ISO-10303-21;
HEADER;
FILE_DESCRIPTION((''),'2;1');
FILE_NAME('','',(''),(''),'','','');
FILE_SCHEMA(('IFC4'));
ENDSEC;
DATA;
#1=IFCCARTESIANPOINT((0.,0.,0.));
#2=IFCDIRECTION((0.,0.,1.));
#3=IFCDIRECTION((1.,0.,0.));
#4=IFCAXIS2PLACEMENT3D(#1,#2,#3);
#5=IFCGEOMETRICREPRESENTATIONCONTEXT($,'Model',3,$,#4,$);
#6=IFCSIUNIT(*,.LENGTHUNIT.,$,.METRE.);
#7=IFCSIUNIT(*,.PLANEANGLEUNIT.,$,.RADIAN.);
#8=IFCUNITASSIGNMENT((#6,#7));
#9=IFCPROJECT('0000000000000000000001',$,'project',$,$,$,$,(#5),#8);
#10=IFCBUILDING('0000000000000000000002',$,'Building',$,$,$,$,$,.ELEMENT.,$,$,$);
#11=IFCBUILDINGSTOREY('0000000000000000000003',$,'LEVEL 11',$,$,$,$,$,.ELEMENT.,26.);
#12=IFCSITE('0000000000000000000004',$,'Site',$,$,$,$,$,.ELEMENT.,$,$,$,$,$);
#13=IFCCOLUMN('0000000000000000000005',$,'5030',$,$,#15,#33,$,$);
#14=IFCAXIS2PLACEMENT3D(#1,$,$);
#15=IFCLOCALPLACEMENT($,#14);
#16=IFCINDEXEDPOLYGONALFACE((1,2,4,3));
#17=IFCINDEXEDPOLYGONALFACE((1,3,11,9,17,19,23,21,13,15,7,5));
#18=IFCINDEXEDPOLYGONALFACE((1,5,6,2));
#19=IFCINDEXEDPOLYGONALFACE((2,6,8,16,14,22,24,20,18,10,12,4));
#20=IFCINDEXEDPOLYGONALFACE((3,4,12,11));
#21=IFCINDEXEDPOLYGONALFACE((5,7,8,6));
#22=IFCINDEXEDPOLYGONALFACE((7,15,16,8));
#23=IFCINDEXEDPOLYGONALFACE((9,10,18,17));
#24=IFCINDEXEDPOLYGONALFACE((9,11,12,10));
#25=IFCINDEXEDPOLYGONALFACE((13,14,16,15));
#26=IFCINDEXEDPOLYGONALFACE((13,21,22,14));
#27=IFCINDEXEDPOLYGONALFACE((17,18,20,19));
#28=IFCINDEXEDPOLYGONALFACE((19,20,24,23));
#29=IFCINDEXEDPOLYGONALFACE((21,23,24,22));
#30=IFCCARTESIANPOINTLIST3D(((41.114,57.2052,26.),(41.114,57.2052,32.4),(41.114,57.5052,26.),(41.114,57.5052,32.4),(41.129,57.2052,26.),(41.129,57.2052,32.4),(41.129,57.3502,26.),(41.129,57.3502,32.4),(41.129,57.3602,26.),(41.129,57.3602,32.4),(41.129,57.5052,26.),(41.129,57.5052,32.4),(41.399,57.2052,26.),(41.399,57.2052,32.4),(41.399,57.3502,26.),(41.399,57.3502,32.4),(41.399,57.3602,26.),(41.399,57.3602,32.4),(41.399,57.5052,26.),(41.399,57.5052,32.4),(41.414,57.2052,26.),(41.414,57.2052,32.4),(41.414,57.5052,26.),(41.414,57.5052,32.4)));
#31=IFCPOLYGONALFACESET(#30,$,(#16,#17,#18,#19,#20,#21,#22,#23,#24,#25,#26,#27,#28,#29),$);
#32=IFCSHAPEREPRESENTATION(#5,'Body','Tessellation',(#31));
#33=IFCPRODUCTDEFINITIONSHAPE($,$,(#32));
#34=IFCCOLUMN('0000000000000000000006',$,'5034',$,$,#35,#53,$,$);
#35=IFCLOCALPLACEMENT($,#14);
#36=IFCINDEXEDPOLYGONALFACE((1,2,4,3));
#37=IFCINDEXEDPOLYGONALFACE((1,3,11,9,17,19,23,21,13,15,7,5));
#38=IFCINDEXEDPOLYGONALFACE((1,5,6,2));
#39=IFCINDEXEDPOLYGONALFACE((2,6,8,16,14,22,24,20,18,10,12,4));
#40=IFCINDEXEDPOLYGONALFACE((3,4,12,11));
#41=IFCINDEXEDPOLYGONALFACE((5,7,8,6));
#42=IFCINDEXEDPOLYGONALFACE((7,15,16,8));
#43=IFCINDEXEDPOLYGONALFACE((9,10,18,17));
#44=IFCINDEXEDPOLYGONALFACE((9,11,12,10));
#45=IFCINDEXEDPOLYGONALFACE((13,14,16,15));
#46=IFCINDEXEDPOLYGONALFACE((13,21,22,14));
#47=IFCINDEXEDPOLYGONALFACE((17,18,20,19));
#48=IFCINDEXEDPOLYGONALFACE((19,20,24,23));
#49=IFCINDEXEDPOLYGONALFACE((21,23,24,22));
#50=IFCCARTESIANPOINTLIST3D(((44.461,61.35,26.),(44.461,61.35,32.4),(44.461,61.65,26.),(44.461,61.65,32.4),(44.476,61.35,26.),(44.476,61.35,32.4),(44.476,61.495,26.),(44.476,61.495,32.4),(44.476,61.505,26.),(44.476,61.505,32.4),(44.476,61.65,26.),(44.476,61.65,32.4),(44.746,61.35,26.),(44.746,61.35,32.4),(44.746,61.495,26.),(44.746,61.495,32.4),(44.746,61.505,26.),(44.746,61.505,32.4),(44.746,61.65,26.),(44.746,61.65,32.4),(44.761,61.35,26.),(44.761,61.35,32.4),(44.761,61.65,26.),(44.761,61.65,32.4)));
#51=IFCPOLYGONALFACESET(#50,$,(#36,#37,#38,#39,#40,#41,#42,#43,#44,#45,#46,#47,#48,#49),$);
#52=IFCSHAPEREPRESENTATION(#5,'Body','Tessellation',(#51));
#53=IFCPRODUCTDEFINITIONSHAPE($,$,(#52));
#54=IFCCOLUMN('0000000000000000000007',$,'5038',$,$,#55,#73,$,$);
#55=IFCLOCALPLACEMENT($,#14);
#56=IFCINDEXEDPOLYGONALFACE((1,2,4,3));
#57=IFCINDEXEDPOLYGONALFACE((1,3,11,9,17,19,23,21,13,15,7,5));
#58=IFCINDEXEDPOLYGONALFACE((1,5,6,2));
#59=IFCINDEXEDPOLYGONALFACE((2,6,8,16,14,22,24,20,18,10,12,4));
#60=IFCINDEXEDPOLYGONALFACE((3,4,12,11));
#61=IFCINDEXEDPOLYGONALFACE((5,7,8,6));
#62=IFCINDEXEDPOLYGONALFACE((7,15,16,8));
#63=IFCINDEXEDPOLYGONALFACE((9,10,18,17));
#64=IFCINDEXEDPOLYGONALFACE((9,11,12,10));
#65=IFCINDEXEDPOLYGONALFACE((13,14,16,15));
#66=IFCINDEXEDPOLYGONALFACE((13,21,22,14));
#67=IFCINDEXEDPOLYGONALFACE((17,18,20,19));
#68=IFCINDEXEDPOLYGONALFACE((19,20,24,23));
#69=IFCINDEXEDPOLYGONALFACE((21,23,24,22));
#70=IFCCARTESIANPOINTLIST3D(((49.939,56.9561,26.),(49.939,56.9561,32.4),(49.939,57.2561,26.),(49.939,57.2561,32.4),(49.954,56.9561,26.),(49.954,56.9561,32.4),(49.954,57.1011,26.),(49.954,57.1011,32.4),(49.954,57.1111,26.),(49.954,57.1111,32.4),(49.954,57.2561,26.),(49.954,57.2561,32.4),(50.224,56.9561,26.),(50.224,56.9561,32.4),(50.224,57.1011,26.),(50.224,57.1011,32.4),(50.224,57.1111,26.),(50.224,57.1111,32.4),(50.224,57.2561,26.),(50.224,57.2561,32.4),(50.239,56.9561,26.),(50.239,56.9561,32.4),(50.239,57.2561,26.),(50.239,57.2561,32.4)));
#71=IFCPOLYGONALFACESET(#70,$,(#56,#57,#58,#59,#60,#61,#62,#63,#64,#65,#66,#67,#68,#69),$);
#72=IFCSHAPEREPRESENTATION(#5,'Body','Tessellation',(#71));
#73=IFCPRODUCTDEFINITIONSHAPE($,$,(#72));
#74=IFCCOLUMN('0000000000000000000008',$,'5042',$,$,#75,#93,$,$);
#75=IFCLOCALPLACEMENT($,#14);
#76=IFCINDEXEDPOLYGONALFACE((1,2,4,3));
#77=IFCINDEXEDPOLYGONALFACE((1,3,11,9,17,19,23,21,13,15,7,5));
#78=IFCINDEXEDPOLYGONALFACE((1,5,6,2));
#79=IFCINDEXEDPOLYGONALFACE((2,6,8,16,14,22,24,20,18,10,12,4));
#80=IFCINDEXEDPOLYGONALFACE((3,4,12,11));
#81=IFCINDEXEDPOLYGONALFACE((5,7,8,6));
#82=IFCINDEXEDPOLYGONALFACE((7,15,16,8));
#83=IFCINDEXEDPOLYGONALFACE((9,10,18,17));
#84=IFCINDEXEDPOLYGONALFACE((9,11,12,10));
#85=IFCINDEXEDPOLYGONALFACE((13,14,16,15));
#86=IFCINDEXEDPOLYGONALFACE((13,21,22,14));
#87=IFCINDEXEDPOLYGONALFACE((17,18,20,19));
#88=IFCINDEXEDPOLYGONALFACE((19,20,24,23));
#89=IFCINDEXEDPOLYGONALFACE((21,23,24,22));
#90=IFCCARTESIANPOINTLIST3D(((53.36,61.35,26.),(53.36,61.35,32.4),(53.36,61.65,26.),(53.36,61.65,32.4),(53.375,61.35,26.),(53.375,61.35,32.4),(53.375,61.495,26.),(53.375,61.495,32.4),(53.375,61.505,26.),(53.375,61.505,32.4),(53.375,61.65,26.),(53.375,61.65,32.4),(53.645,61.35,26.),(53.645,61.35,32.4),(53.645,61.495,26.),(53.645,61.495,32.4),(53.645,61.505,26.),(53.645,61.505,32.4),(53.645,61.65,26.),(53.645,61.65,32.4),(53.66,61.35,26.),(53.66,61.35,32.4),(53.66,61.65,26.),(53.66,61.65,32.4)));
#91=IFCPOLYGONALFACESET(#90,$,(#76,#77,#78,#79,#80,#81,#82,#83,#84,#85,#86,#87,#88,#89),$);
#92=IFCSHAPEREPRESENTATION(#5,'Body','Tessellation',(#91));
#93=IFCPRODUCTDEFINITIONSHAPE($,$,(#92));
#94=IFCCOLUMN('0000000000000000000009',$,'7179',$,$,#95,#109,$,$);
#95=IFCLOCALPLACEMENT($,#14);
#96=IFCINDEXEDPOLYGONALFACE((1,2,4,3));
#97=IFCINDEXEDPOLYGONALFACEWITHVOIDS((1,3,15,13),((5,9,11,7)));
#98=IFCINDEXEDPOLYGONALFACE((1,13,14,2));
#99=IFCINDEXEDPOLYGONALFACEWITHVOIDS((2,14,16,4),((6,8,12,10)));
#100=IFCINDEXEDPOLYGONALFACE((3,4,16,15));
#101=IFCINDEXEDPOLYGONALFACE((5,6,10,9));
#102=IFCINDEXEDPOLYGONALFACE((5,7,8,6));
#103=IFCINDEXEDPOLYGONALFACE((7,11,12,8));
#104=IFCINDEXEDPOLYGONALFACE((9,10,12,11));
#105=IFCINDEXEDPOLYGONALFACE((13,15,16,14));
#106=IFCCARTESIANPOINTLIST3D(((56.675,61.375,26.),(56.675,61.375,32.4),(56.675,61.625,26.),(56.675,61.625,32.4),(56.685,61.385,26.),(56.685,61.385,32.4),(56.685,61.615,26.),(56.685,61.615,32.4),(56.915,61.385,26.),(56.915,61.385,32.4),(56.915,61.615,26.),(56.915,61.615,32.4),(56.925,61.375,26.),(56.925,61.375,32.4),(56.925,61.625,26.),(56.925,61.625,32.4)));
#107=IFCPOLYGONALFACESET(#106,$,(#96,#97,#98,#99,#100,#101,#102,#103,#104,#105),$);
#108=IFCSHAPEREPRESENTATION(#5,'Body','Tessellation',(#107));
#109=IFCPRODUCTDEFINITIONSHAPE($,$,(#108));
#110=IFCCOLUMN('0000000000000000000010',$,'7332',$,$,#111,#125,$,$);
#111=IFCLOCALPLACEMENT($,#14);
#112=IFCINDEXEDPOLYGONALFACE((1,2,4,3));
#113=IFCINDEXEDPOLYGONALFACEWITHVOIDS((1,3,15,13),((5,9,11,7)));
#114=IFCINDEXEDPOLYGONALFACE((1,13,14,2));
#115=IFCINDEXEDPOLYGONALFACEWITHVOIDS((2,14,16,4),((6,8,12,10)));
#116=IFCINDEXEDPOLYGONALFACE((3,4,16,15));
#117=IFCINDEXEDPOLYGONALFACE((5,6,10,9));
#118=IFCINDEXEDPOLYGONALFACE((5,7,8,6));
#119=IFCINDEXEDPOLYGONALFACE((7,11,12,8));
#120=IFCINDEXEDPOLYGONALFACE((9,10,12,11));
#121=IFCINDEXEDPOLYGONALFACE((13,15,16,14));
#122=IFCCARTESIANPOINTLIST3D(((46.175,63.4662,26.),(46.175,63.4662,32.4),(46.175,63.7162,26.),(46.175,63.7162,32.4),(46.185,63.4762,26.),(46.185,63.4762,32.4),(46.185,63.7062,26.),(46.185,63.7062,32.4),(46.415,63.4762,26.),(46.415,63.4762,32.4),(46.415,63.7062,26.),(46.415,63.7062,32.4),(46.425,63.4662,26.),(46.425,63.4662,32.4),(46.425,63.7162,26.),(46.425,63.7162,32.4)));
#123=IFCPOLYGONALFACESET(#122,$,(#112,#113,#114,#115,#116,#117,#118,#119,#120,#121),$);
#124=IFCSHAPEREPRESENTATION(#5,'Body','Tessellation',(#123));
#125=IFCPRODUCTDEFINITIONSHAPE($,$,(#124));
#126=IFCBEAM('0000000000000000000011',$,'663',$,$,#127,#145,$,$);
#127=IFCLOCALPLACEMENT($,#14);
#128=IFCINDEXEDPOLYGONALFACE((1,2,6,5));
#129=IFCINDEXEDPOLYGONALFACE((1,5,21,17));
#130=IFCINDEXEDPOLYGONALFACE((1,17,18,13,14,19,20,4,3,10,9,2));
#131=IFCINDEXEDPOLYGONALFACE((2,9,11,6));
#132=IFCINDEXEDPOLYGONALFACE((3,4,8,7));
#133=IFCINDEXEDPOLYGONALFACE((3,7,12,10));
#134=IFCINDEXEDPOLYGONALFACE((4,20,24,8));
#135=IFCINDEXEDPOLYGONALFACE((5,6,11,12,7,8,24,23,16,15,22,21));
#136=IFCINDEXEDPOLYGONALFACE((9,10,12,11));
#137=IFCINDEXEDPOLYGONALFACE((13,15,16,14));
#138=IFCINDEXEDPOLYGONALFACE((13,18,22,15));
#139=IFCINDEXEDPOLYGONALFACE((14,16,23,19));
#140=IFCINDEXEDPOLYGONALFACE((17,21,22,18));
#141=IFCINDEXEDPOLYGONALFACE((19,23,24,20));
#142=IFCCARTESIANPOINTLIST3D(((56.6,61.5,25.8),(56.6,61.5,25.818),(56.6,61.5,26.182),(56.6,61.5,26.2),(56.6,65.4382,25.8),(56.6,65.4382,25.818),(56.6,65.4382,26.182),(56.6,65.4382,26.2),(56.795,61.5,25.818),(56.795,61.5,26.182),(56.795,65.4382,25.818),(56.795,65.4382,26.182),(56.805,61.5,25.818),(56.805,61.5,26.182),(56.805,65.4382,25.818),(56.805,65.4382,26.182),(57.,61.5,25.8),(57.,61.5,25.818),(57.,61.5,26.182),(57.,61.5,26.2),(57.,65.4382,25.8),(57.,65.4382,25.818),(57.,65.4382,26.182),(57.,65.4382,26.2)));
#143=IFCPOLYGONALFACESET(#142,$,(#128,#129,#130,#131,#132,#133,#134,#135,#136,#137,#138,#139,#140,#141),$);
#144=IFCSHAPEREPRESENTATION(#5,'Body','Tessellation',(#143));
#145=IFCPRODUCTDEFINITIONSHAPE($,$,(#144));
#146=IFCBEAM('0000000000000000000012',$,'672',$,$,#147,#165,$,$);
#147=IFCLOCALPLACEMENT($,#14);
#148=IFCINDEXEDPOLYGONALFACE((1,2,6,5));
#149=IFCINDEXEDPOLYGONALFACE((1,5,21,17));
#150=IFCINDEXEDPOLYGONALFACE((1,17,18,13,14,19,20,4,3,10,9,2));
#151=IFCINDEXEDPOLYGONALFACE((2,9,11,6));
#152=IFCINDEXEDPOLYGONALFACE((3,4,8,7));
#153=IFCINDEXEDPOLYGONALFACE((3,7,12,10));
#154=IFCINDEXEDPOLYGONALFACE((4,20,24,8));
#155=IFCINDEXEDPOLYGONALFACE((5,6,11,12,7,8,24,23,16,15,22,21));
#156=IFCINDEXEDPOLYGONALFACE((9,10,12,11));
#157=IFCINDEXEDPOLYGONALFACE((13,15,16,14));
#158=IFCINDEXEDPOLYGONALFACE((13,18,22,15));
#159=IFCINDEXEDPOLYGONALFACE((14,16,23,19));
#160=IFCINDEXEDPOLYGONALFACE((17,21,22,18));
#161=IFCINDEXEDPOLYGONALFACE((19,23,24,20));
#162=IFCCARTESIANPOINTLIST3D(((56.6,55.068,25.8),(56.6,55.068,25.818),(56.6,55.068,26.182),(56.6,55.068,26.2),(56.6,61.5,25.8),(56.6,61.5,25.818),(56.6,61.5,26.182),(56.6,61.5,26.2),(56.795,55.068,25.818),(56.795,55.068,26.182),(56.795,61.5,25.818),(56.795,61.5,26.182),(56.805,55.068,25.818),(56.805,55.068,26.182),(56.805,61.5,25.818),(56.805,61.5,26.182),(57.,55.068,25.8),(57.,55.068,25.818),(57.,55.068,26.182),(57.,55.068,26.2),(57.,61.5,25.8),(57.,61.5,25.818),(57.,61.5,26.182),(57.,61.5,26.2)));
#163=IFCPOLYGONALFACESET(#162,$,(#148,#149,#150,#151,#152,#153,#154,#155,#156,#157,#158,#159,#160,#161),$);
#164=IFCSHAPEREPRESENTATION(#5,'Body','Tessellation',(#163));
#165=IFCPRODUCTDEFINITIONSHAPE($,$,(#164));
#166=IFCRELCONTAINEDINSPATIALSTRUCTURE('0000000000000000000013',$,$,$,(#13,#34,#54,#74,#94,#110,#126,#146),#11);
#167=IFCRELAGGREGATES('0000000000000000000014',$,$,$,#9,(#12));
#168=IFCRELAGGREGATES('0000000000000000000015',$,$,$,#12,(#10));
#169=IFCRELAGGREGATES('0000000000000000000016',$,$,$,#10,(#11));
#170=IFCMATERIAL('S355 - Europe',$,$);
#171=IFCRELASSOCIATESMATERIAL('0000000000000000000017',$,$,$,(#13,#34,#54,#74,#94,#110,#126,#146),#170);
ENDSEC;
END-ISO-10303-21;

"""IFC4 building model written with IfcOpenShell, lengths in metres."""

from ifc_helpers import new_model, si_unit, frame, origin_with_axes, origin_2d_with_axis, place, context, project, spatial, hollow_rectangle, i_section, extrude, material, material_profile, profile_set, profile_usage, element, save


model = new_model("IFC4")

# Units and contexts
model_context = context("Model", 3, world=origin_with_axes())
ifc_project = project(units=[si_unit("LENGTHUNIT", "METRE"), si_unit("PLANEANGLEUNIT", "RADIAN")], contexts=[model_context])

# Site, building, storey
site = spatial("IfcSite", under=ifc_project, Name="Site", CompositionType="ELEMENT")
building = spatial("IfcBuilding", under=site, Name="Building", CompositionType="ELEMENT")
storey = spatial("IfcBuildingStorey", under=building, Name="LEVEL 11", CompositionType="ELEMENT", Elevation=26.0)

# Columns
ifc_material = material(Name="S355 - Europe")
ifc_material_profile_1 = material_profile(ifc_material, i_section(OverallWidth=0.3, OverallDepth=0.3, WebThickness=0.01, FlangeThickness=0.015, at=origin_2d_with_axis()))
ifc_profile_set_1 = profile_set([ifc_material_profile_1])
ifc_profile_usage_1 = profile_usage(ifc_profile_set_1, cardinal=10)
column_1_placement = place(None, frame((41.264, 57.3552, 26.0), z_axis=(0.0, 0.0, 1.0), x_axis=(0.0, -1.0, 0.0)))
element("IfcColumn", 1, at=column_1_placement, inside=storey, material=ifc_profile_usage_1, Name="5030", context=model_context, shape_type="SweptSolid", body=[
    extrude(i_section(OverallWidth=0.3, OverallDepth=0.3, WebThickness=0.01, FlangeThickness=0.015, at=origin_2d_with_axis()), origin_with_axes(), (0.0, 0.0, 1.0), 6.4),
])
ifc_material_profile_2 = material_profile(ifc_material, i_section(OverallWidth=0.3, OverallDepth=0.3, WebThickness=0.01, FlangeThickness=0.015, at=origin_2d_with_axis()))
ifc_profile_set_2 = profile_set([ifc_material_profile_2])
ifc_profile_usage_2 = profile_usage(ifc_profile_set_2, cardinal=10)
column_2_placement = place(None, frame((44.611, 61.5, 26.0), z_axis=(0.0, 0.0, 1.0), x_axis=(0.0, -1.0, 0.0)))
element("IfcColumn", 2, at=column_2_placement, inside=storey, material=ifc_profile_usage_2, Name="5034", context=model_context, shape_type="SweptSolid", body=[
    extrude(i_section(OverallWidth=0.3, OverallDepth=0.3, WebThickness=0.01, FlangeThickness=0.015, at=origin_2d_with_axis()), origin_with_axes(), (0.0, 0.0, 1.0), 6.4),
])
ifc_material_profile_3 = material_profile(ifc_material, i_section(OverallWidth=0.3, OverallDepth=0.3, WebThickness=0.01, FlangeThickness=0.015, at=origin_2d_with_axis()))
ifc_profile_set_3 = profile_set([ifc_material_profile_3])
ifc_profile_usage_3 = profile_usage(ifc_profile_set_3, cardinal=10)
column_3_placement = place(None, frame((50.089, 57.1061, 26.0), z_axis=(0.0, 0.0, 1.0), x_axis=(0.0, -1.0, 0.0)))
element("IfcColumn", 3, at=column_3_placement, inside=storey, material=ifc_profile_usage_3, Name="5038", context=model_context, shape_type="SweptSolid", body=[
    extrude(i_section(OverallWidth=0.3, OverallDepth=0.3, WebThickness=0.01, FlangeThickness=0.015, at=origin_2d_with_axis()), origin_with_axes(), (0.0, 0.0, 1.0), 6.4),
])
ifc_material_profile_4 = material_profile(ifc_material, i_section(OverallWidth=0.3, OverallDepth=0.3, WebThickness=0.01, FlangeThickness=0.015, at=origin_2d_with_axis()))
ifc_profile_set_4 = profile_set([ifc_material_profile_4])
ifc_profile_usage_4 = profile_usage(ifc_profile_set_4, cardinal=10)
column_4_placement = place(None, frame((53.51, 61.5, 26.0), z_axis=(0.0, 0.0, 1.0), x_axis=(0.0, -1.0, 0.0)))
element("IfcColumn", 4, at=column_4_placement, inside=storey, material=ifc_profile_usage_4, Name="5042", context=model_context, shape_type="SweptSolid", body=[
    extrude(i_section(OverallWidth=0.3, OverallDepth=0.3, WebThickness=0.01, FlangeThickness=0.015, at=origin_2d_with_axis()), origin_with_axes(), (0.0, 0.0, 1.0), 6.4),
])
ifc_material_profile_5 = material_profile(ifc_material, hollow_rectangle(XDim=0.25, YDim=0.25, WallThickness=0.01, at=origin_2d_with_axis()))
ifc_profile_set_5 = profile_set([ifc_material_profile_5])
ifc_profile_usage_5 = profile_usage(ifc_profile_set_5, cardinal=10)
column_5_placement = place(None, frame((56.8, 61.5, 26.0), z_axis=(0.0, 0.0, 1.0), x_axis=(0.0, -1.0, 0.0)))
element("IfcColumn", 5, at=column_5_placement, inside=storey, material=ifc_profile_usage_5, Name="7179", context=model_context, shape_type="SweptSolid", body=[
    extrude(hollow_rectangle(XDim=0.25, YDim=0.25, WallThickness=0.01, at=origin_2d_with_axis()), origin_with_axes(), (0.0, 0.0, 1.0), 6.4),
])
ifc_material_profile_6 = material_profile(ifc_material, hollow_rectangle(XDim=0.25, YDim=0.25, WallThickness=0.01, at=origin_2d_with_axis()))
ifc_profile_set_6 = profile_set([ifc_material_profile_6])
ifc_profile_usage_6 = profile_usage(ifc_profile_set_6, cardinal=10)
column_6_placement = place(None, frame((46.3, 63.5912, 26.0), z_axis=(0.0, 0.0, 1.0), x_axis=(0.0, -1.0, 0.0)))
element("IfcColumn", 6, at=column_6_placement, inside=storey, material=ifc_profile_usage_6, Name="7332", context=model_context, shape_type="SweptSolid", body=[
    extrude(hollow_rectangle(XDim=0.25, YDim=0.25, WallThickness=0.01, at=origin_2d_with_axis()), origin_with_axes(), (0.0, 0.0, 1.0), 6.4),
])

# Beams
ifc_material_profile_7 = material_profile(ifc_material, i_section(OverallWidth=0.4, OverallDepth=0.4, WebThickness=0.01, FlangeThickness=0.018, at=origin_2d_with_axis()))
ifc_profile_set_7 = profile_set([ifc_material_profile_7])
ifc_profile_usage_7 = profile_usage(ifc_profile_set_7, cardinal=10)
beam_1_placement = place(None, frame((56.8, 61.5, 26.0), z_axis=(0.0, 1.0, 0.0), x_axis=(-1.0, 0.0, 0.0)))
element("IfcBeam", 7, at=beam_1_placement, inside=storey, material=ifc_profile_usage_7, Name="663", context=model_context, shape_type="SweptSolid", body=[
    extrude(i_section(OverallWidth=0.4, OverallDepth=0.4, WebThickness=0.01, FlangeThickness=0.018, at=origin_2d_with_axis()), origin_with_axes(), (0.0, 0.0, 1.0), 3.9382),
])
ifc_material_profile_8 = material_profile(ifc_material, i_section(OverallWidth=0.4, OverallDepth=0.4, WebThickness=0.01, FlangeThickness=0.018, at=origin_2d_with_axis()))
ifc_profile_set_8 = profile_set([ifc_material_profile_8])
ifc_profile_usage_8 = profile_usage(ifc_profile_set_8, cardinal=10)
beam_2_placement = place(None, frame((56.8, 55.068, 26.0), z_axis=(0.0, 1.0, 0.0), x_axis=(-1.0, 0.0, 0.0)))
element("IfcBeam", 8, at=beam_2_placement, inside=storey, material=ifc_profile_usage_8, Name="672", context=model_context, shape_type="SweptSolid", body=[
    extrude(i_section(OverallWidth=0.4, OverallDepth=0.4, WebThickness=0.01, FlangeThickness=0.018, at=origin_2d_with_axis()), origin_with_axes(), (0.0, 0.0, 1.0), 6.432),
])

save(model, "model.ifc")
